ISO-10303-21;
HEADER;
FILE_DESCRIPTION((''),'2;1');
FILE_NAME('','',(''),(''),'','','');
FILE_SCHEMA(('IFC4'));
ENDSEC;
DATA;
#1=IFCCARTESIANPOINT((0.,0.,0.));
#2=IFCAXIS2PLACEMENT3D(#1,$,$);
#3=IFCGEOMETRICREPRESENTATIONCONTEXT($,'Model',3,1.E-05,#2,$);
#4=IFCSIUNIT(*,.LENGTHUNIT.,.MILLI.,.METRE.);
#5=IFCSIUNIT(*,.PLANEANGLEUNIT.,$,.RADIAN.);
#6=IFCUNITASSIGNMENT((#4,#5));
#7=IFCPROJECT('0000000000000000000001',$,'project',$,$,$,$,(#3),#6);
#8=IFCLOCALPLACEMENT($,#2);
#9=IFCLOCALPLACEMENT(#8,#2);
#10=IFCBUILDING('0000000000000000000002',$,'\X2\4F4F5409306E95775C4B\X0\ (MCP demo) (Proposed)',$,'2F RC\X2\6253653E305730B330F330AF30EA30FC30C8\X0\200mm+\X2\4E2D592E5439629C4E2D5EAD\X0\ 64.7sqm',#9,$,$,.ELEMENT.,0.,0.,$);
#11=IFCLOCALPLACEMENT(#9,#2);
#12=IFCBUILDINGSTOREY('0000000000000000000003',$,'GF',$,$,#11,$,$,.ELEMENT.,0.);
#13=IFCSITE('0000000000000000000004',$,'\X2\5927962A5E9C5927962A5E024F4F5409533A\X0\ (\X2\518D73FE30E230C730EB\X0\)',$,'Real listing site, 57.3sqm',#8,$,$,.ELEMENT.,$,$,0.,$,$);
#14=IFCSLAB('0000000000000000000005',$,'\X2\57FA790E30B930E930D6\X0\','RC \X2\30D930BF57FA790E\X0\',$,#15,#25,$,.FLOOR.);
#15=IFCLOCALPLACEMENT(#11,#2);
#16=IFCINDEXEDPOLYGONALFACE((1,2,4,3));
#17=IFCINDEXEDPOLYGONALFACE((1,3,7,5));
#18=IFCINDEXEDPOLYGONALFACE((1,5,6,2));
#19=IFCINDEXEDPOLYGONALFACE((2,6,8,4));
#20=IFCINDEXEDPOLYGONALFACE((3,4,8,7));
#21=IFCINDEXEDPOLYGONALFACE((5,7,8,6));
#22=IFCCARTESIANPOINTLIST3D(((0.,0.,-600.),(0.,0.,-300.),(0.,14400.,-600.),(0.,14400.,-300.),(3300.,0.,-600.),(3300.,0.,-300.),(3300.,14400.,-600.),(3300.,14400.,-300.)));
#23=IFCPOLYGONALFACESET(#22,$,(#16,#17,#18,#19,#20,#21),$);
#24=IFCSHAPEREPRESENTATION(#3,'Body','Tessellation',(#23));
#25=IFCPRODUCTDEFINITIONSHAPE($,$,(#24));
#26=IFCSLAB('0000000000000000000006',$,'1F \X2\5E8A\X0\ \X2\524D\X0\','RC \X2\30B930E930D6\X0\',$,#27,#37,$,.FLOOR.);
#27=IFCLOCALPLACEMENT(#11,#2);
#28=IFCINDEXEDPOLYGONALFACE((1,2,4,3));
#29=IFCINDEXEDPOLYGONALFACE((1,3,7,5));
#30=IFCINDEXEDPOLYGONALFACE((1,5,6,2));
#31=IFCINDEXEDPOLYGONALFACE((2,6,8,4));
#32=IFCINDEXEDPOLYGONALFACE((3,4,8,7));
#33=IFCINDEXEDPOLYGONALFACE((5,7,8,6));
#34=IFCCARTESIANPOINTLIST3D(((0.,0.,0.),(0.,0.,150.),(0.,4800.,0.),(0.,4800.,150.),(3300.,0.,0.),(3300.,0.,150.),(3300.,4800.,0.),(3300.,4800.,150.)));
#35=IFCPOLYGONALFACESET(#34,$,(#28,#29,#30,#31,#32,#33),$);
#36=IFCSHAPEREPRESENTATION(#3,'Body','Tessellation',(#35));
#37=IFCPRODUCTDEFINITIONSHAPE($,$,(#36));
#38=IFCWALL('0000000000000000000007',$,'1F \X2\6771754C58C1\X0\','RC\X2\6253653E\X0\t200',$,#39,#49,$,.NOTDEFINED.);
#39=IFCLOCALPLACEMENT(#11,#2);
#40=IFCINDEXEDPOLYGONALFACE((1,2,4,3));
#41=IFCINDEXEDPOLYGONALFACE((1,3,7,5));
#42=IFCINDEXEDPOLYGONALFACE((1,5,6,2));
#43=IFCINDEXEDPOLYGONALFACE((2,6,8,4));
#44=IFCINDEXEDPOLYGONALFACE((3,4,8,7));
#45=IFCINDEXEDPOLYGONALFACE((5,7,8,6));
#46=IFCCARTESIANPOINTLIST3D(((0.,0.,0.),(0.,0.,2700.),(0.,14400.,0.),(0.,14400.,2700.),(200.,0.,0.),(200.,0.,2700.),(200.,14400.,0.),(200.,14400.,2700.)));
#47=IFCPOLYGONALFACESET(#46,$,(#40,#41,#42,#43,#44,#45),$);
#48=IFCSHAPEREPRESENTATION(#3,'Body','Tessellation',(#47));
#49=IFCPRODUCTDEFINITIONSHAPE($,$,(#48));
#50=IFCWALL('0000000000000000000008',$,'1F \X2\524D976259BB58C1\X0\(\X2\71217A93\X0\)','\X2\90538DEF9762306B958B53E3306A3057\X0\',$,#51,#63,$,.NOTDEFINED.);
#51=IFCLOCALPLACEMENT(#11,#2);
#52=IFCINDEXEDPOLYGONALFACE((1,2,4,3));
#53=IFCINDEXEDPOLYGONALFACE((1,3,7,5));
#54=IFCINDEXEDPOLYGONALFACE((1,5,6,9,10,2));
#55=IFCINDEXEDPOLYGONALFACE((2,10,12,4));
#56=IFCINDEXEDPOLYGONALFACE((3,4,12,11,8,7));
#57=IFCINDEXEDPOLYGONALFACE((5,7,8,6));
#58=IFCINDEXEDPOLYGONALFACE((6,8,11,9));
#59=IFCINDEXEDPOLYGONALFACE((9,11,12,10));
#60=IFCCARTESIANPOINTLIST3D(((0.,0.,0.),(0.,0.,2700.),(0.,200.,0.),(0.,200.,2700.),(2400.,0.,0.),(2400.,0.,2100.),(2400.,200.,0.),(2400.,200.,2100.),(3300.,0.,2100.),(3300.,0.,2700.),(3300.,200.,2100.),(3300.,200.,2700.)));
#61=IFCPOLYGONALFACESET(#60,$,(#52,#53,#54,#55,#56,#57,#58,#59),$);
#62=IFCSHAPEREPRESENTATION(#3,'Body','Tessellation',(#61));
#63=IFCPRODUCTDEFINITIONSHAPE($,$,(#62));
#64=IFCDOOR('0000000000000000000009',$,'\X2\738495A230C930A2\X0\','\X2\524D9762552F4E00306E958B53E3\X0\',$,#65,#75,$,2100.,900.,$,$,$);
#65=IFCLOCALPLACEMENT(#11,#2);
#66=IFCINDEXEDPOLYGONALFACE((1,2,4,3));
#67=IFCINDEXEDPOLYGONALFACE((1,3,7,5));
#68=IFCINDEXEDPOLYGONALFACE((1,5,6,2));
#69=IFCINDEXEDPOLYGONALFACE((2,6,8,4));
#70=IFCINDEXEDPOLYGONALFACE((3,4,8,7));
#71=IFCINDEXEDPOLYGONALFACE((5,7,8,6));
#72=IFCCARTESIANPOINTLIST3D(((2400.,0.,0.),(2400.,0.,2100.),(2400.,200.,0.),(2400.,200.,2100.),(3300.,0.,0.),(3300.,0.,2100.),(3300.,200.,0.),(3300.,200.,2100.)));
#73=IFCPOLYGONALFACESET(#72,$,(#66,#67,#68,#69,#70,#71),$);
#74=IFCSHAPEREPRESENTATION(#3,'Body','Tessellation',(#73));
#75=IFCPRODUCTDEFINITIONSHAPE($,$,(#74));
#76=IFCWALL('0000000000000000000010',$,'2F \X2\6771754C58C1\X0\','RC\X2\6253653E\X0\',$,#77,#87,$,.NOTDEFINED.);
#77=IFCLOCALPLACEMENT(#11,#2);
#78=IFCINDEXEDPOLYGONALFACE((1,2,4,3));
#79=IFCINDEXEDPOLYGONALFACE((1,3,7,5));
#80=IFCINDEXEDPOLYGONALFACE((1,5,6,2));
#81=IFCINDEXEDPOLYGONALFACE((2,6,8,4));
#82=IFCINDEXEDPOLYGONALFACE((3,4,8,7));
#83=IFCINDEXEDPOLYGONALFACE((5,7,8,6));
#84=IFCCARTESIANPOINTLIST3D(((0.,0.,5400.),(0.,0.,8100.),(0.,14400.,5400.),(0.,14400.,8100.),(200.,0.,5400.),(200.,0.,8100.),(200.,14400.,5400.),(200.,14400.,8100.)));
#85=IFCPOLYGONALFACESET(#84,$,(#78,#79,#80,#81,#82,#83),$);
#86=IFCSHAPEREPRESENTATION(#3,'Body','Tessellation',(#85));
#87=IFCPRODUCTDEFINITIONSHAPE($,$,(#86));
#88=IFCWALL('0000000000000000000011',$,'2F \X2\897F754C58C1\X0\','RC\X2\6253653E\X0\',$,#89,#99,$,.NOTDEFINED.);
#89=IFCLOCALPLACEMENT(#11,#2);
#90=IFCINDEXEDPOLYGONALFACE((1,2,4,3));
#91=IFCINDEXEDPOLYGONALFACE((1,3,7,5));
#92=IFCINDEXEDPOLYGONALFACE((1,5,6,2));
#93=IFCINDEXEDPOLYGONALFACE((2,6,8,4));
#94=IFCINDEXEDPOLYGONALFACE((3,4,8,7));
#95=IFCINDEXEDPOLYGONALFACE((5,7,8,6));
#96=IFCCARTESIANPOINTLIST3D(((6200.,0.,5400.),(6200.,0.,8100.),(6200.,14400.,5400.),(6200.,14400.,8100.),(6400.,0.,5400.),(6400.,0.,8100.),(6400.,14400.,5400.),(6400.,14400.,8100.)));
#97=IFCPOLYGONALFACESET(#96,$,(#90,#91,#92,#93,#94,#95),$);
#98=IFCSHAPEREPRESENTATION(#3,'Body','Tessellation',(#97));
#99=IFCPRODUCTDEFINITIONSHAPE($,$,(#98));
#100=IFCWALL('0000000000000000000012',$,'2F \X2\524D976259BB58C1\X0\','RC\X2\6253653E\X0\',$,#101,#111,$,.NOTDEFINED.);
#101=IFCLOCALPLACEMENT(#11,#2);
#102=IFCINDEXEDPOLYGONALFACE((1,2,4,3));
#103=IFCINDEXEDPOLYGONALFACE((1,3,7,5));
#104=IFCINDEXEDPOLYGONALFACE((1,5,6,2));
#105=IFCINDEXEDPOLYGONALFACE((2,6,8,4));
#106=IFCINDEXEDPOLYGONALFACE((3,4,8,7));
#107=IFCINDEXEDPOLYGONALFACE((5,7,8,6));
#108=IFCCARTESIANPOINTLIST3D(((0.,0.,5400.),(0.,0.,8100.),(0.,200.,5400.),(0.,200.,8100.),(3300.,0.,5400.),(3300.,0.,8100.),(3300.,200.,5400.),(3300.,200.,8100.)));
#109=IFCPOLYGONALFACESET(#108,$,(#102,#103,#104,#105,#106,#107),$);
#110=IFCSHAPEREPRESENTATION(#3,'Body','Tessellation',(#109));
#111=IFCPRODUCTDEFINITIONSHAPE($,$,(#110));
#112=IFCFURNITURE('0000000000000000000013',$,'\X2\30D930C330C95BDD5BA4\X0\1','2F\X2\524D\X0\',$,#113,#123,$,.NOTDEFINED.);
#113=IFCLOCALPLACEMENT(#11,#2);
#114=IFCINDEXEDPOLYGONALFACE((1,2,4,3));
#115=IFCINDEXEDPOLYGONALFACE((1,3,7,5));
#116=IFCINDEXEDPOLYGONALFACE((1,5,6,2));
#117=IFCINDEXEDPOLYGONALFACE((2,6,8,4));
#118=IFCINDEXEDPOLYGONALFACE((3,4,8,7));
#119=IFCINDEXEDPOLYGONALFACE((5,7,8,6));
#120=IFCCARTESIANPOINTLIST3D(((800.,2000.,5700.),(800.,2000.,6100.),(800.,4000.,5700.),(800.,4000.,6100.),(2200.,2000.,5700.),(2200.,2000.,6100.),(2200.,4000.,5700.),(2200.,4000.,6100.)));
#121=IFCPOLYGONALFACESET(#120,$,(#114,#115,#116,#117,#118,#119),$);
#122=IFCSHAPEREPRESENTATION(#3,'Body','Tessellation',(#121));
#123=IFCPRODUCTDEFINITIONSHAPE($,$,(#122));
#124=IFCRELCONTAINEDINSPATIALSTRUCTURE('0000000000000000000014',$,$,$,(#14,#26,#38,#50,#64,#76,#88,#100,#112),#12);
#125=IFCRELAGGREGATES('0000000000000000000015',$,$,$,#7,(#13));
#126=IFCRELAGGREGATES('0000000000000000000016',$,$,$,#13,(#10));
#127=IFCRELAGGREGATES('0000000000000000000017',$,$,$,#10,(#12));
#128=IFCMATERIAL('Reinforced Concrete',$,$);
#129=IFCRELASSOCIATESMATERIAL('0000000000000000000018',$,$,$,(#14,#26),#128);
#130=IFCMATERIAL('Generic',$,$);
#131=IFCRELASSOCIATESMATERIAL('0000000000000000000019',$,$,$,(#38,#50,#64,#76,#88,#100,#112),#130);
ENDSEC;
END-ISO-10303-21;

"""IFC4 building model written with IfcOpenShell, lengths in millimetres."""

from ifc_helpers import new_model, si_unit, frame, frame_2d, origin, place, context, project, spatial, rectangle, extrude, material, element, fill, save


model = new_model("IFC4")

# Units and contexts
model_context = context("Model", 3, precision=1e-05, world=origin())
ifc_project = project(units=[si_unit("LENGTHUNIT", "METRE", prefix="MILLI"), si_unit("PLANEANGLEUNIT", "RADIAN")], contexts=[model_context])

# Site, building, storey
site_placement = place(None, origin())
site = spatial("IfcSite", under=ifc_project, at=site_placement, Name="大阪府大阪市住吉区 (再現モデル)", ObjectType="Real listing site, 57.3sqm", CompositionType="ELEMENT", RefElevation=0.0)
building_placement = place(site_placement, origin())
building = spatial("IfcBuilding", under=site, at=building_placement, Name="住吉の長屋 (MCP demo) (Proposed)", ObjectType="2F RC打放しコンクリート200mm+中央吹抜中庭 64.7sqm", CompositionType="ELEMENT", ElevationOfRefHeight=0.0, ElevationOfTerrain=0.0)
storey_placement = place(building_placement, origin())
storey = spatial("IfcBuildingStorey", under=building, at=storey_placement, Name="GF", CompositionType="ELEMENT", Elevation=0.0)

# Slabs
ifc_material_1 = material(Name="Reinforced Concrete")
slab_1_placement = place(storey_placement, frame((0.0, 0.0, -300.0)))
element("IfcSlab", 1, at=slab_1_placement, inside=storey, material=ifc_material_1, Name="基礎スラブ", Description="RC ベタ基礎", PredefinedType="FLOOR", context=model_context, shape_type="SweptSolid", body=[
    extrude(rectangle(XDim=3300.0, YDim=14400.0, at=frame_2d((1650.0, 7200.0))), frame((0.0, 0.0, -300.0)), (0.0, 0.0, 1.0), 300.0),
])
slab_2_placement = place(storey_placement, origin())
element("IfcSlab", 2, at=slab_2_placement, inside=storey, material=ifc_material_1, Name="1F 床 前", Description="RC スラブ", PredefinedType="FLOOR", context=model_context, shape_type="SweptSolid", body=[
    extrude(rectangle(XDim=3300.0, YDim=4800.0, at=frame_2d((1650.0, 2400.0))), origin(), (0.0, 0.0, 1.0), 150.0),
])

# Wall
ifc_material_2 = material(Name="Generic")
wall_1_placement = place(storey_placement, origin())
element("IfcWall", 3, at=wall_1_placement, inside=storey, material=ifc_material_2, Name="1F 東界壁", Description="RC打放t200", PredefinedType="NOTDEFINED", context=model_context, shape_type="SweptSolid", body=[
    extrude(rectangle(XDim=200.0, YDim=14400.0, at=frame_2d((100.0, 7200.0))), origin(), (0.0, 0.0, 1.0), 2700.0),
])

# Wall, opening, door
wall_2_placement = place(storey_placement, origin())
wall_2 = element("IfcWall", 4, at=wall_2_placement, inside=storey, material=ifc_material_2, Name="1F 前面妻壁(無窓)", Description="道路面に開口なし", PredefinedType="NOTDEFINED", context=model_context, shape_type="SweptSolid", body=[
    extrude(rectangle(XDim=3300.0, YDim=200.0, at=frame_2d((1650.0, 100.0))), origin(), (0.0, 0.0, 1.0), 2700.0),
])
opening_placement = place(storey_placement, frame((1200.0, 0.0, 0.0)))
opening = element("IfcOpeningElement", 5, at=opening_placement, cuts=wall_2, PredefinedType="NOTDEFINED", context=model_context, shape_type="SweptSolid", body=[
    extrude(rectangle(XDim=900.0, YDim=200.0, at=frame_2d((450.0, 100.0))), frame((1200.0, 0.0, 0.0)), (0.0, 0.0, 1.0), 2100.0),
])
door_placement = place(storey_placement, frame((1200.0, 0.0, 0.0)))
door = element("IfcDoor", 6, at=door_placement, inside=storey, material=ifc_material_2, Name="玄関ドア", Description="前面唯一の開口", OverallHeight=2100.0, OverallWidth=900.0, context=model_context, shape_type="SweptSolid", body=[
    extrude(rectangle(XDim=900.0, YDim=200.0, at=frame_2d((450.0, 100.0))), frame((1200.0, 0.0, 0.0)), (0.0, 0.0, 1.0), 2100.0),
])
fill(opening, door)

# Walls
wall_3_placement = place(storey_placement, frame((0.0, 0.0, 2700.0)))
element("IfcWall", 7, at=wall_3_placement, inside=storey, material=ifc_material_2, Name="2F 東界壁", Description="RC打放", PredefinedType="NOTDEFINED", context=model_context, shape_type="SweptSolid", body=[
    extrude(rectangle(XDim=200.0, YDim=14400.0, at=frame_2d((100.0, 7200.0))), frame((0.0, 0.0, 2700.0)), (0.0, 0.0, 1.0), 2700.0),
])
wall_4_placement = place(storey_placement, frame((3100.0, 0.0, 2700.0)))
element("IfcWall", 8, at=wall_4_placement, inside=storey, material=ifc_material_2, Name="2F 西界壁", Description="RC打放", PredefinedType="NOTDEFINED", context=model_context, shape_type="SweptSolid", body=[
    extrude(rectangle(XDim=200.0, YDim=14400.0, at=frame_2d((100.0, 7200.0))), frame((3100.0, 0.0, 2700.0)), (0.0, 0.0, 1.0), 2700.0),
])
wall_5_placement = place(storey_placement, frame((0.0, 0.0, 2700.0)))
element("IfcWall", 9, at=wall_5_placement, inside=storey, material=ifc_material_2, Name="2F 前面妻壁", Description="RC打放", PredefinedType="NOTDEFINED", context=model_context, shape_type="SweptSolid", body=[
    extrude(rectangle(XDim=3300.0, YDim=200.0, at=frame_2d((1650.0, 100.0))), frame((0.0, 0.0, 2700.0)), (0.0, 0.0, 1.0), 2700.0),
])

# Furniture
furniture_1_placement = place(storey_placement, frame((400.0, 1000.0, 2850.0)))
element("IfcFurniture", 10, at=furniture_1_placement, inside=storey, material=ifc_material_2, Name="ベッド寝室1", Description="2F前", PredefinedType="NOTDEFINED", context=model_context, shape_type="SweptSolid", body=[
    extrude(rectangle(XDim=1400.0, YDim=2000.0, at=frame_2d((700.0, 1000.0))), frame((400.0, 1000.0, 2850.0)), (0.0, 0.0, 1.0), 400.0),
])

save(model, "model.ifc")
